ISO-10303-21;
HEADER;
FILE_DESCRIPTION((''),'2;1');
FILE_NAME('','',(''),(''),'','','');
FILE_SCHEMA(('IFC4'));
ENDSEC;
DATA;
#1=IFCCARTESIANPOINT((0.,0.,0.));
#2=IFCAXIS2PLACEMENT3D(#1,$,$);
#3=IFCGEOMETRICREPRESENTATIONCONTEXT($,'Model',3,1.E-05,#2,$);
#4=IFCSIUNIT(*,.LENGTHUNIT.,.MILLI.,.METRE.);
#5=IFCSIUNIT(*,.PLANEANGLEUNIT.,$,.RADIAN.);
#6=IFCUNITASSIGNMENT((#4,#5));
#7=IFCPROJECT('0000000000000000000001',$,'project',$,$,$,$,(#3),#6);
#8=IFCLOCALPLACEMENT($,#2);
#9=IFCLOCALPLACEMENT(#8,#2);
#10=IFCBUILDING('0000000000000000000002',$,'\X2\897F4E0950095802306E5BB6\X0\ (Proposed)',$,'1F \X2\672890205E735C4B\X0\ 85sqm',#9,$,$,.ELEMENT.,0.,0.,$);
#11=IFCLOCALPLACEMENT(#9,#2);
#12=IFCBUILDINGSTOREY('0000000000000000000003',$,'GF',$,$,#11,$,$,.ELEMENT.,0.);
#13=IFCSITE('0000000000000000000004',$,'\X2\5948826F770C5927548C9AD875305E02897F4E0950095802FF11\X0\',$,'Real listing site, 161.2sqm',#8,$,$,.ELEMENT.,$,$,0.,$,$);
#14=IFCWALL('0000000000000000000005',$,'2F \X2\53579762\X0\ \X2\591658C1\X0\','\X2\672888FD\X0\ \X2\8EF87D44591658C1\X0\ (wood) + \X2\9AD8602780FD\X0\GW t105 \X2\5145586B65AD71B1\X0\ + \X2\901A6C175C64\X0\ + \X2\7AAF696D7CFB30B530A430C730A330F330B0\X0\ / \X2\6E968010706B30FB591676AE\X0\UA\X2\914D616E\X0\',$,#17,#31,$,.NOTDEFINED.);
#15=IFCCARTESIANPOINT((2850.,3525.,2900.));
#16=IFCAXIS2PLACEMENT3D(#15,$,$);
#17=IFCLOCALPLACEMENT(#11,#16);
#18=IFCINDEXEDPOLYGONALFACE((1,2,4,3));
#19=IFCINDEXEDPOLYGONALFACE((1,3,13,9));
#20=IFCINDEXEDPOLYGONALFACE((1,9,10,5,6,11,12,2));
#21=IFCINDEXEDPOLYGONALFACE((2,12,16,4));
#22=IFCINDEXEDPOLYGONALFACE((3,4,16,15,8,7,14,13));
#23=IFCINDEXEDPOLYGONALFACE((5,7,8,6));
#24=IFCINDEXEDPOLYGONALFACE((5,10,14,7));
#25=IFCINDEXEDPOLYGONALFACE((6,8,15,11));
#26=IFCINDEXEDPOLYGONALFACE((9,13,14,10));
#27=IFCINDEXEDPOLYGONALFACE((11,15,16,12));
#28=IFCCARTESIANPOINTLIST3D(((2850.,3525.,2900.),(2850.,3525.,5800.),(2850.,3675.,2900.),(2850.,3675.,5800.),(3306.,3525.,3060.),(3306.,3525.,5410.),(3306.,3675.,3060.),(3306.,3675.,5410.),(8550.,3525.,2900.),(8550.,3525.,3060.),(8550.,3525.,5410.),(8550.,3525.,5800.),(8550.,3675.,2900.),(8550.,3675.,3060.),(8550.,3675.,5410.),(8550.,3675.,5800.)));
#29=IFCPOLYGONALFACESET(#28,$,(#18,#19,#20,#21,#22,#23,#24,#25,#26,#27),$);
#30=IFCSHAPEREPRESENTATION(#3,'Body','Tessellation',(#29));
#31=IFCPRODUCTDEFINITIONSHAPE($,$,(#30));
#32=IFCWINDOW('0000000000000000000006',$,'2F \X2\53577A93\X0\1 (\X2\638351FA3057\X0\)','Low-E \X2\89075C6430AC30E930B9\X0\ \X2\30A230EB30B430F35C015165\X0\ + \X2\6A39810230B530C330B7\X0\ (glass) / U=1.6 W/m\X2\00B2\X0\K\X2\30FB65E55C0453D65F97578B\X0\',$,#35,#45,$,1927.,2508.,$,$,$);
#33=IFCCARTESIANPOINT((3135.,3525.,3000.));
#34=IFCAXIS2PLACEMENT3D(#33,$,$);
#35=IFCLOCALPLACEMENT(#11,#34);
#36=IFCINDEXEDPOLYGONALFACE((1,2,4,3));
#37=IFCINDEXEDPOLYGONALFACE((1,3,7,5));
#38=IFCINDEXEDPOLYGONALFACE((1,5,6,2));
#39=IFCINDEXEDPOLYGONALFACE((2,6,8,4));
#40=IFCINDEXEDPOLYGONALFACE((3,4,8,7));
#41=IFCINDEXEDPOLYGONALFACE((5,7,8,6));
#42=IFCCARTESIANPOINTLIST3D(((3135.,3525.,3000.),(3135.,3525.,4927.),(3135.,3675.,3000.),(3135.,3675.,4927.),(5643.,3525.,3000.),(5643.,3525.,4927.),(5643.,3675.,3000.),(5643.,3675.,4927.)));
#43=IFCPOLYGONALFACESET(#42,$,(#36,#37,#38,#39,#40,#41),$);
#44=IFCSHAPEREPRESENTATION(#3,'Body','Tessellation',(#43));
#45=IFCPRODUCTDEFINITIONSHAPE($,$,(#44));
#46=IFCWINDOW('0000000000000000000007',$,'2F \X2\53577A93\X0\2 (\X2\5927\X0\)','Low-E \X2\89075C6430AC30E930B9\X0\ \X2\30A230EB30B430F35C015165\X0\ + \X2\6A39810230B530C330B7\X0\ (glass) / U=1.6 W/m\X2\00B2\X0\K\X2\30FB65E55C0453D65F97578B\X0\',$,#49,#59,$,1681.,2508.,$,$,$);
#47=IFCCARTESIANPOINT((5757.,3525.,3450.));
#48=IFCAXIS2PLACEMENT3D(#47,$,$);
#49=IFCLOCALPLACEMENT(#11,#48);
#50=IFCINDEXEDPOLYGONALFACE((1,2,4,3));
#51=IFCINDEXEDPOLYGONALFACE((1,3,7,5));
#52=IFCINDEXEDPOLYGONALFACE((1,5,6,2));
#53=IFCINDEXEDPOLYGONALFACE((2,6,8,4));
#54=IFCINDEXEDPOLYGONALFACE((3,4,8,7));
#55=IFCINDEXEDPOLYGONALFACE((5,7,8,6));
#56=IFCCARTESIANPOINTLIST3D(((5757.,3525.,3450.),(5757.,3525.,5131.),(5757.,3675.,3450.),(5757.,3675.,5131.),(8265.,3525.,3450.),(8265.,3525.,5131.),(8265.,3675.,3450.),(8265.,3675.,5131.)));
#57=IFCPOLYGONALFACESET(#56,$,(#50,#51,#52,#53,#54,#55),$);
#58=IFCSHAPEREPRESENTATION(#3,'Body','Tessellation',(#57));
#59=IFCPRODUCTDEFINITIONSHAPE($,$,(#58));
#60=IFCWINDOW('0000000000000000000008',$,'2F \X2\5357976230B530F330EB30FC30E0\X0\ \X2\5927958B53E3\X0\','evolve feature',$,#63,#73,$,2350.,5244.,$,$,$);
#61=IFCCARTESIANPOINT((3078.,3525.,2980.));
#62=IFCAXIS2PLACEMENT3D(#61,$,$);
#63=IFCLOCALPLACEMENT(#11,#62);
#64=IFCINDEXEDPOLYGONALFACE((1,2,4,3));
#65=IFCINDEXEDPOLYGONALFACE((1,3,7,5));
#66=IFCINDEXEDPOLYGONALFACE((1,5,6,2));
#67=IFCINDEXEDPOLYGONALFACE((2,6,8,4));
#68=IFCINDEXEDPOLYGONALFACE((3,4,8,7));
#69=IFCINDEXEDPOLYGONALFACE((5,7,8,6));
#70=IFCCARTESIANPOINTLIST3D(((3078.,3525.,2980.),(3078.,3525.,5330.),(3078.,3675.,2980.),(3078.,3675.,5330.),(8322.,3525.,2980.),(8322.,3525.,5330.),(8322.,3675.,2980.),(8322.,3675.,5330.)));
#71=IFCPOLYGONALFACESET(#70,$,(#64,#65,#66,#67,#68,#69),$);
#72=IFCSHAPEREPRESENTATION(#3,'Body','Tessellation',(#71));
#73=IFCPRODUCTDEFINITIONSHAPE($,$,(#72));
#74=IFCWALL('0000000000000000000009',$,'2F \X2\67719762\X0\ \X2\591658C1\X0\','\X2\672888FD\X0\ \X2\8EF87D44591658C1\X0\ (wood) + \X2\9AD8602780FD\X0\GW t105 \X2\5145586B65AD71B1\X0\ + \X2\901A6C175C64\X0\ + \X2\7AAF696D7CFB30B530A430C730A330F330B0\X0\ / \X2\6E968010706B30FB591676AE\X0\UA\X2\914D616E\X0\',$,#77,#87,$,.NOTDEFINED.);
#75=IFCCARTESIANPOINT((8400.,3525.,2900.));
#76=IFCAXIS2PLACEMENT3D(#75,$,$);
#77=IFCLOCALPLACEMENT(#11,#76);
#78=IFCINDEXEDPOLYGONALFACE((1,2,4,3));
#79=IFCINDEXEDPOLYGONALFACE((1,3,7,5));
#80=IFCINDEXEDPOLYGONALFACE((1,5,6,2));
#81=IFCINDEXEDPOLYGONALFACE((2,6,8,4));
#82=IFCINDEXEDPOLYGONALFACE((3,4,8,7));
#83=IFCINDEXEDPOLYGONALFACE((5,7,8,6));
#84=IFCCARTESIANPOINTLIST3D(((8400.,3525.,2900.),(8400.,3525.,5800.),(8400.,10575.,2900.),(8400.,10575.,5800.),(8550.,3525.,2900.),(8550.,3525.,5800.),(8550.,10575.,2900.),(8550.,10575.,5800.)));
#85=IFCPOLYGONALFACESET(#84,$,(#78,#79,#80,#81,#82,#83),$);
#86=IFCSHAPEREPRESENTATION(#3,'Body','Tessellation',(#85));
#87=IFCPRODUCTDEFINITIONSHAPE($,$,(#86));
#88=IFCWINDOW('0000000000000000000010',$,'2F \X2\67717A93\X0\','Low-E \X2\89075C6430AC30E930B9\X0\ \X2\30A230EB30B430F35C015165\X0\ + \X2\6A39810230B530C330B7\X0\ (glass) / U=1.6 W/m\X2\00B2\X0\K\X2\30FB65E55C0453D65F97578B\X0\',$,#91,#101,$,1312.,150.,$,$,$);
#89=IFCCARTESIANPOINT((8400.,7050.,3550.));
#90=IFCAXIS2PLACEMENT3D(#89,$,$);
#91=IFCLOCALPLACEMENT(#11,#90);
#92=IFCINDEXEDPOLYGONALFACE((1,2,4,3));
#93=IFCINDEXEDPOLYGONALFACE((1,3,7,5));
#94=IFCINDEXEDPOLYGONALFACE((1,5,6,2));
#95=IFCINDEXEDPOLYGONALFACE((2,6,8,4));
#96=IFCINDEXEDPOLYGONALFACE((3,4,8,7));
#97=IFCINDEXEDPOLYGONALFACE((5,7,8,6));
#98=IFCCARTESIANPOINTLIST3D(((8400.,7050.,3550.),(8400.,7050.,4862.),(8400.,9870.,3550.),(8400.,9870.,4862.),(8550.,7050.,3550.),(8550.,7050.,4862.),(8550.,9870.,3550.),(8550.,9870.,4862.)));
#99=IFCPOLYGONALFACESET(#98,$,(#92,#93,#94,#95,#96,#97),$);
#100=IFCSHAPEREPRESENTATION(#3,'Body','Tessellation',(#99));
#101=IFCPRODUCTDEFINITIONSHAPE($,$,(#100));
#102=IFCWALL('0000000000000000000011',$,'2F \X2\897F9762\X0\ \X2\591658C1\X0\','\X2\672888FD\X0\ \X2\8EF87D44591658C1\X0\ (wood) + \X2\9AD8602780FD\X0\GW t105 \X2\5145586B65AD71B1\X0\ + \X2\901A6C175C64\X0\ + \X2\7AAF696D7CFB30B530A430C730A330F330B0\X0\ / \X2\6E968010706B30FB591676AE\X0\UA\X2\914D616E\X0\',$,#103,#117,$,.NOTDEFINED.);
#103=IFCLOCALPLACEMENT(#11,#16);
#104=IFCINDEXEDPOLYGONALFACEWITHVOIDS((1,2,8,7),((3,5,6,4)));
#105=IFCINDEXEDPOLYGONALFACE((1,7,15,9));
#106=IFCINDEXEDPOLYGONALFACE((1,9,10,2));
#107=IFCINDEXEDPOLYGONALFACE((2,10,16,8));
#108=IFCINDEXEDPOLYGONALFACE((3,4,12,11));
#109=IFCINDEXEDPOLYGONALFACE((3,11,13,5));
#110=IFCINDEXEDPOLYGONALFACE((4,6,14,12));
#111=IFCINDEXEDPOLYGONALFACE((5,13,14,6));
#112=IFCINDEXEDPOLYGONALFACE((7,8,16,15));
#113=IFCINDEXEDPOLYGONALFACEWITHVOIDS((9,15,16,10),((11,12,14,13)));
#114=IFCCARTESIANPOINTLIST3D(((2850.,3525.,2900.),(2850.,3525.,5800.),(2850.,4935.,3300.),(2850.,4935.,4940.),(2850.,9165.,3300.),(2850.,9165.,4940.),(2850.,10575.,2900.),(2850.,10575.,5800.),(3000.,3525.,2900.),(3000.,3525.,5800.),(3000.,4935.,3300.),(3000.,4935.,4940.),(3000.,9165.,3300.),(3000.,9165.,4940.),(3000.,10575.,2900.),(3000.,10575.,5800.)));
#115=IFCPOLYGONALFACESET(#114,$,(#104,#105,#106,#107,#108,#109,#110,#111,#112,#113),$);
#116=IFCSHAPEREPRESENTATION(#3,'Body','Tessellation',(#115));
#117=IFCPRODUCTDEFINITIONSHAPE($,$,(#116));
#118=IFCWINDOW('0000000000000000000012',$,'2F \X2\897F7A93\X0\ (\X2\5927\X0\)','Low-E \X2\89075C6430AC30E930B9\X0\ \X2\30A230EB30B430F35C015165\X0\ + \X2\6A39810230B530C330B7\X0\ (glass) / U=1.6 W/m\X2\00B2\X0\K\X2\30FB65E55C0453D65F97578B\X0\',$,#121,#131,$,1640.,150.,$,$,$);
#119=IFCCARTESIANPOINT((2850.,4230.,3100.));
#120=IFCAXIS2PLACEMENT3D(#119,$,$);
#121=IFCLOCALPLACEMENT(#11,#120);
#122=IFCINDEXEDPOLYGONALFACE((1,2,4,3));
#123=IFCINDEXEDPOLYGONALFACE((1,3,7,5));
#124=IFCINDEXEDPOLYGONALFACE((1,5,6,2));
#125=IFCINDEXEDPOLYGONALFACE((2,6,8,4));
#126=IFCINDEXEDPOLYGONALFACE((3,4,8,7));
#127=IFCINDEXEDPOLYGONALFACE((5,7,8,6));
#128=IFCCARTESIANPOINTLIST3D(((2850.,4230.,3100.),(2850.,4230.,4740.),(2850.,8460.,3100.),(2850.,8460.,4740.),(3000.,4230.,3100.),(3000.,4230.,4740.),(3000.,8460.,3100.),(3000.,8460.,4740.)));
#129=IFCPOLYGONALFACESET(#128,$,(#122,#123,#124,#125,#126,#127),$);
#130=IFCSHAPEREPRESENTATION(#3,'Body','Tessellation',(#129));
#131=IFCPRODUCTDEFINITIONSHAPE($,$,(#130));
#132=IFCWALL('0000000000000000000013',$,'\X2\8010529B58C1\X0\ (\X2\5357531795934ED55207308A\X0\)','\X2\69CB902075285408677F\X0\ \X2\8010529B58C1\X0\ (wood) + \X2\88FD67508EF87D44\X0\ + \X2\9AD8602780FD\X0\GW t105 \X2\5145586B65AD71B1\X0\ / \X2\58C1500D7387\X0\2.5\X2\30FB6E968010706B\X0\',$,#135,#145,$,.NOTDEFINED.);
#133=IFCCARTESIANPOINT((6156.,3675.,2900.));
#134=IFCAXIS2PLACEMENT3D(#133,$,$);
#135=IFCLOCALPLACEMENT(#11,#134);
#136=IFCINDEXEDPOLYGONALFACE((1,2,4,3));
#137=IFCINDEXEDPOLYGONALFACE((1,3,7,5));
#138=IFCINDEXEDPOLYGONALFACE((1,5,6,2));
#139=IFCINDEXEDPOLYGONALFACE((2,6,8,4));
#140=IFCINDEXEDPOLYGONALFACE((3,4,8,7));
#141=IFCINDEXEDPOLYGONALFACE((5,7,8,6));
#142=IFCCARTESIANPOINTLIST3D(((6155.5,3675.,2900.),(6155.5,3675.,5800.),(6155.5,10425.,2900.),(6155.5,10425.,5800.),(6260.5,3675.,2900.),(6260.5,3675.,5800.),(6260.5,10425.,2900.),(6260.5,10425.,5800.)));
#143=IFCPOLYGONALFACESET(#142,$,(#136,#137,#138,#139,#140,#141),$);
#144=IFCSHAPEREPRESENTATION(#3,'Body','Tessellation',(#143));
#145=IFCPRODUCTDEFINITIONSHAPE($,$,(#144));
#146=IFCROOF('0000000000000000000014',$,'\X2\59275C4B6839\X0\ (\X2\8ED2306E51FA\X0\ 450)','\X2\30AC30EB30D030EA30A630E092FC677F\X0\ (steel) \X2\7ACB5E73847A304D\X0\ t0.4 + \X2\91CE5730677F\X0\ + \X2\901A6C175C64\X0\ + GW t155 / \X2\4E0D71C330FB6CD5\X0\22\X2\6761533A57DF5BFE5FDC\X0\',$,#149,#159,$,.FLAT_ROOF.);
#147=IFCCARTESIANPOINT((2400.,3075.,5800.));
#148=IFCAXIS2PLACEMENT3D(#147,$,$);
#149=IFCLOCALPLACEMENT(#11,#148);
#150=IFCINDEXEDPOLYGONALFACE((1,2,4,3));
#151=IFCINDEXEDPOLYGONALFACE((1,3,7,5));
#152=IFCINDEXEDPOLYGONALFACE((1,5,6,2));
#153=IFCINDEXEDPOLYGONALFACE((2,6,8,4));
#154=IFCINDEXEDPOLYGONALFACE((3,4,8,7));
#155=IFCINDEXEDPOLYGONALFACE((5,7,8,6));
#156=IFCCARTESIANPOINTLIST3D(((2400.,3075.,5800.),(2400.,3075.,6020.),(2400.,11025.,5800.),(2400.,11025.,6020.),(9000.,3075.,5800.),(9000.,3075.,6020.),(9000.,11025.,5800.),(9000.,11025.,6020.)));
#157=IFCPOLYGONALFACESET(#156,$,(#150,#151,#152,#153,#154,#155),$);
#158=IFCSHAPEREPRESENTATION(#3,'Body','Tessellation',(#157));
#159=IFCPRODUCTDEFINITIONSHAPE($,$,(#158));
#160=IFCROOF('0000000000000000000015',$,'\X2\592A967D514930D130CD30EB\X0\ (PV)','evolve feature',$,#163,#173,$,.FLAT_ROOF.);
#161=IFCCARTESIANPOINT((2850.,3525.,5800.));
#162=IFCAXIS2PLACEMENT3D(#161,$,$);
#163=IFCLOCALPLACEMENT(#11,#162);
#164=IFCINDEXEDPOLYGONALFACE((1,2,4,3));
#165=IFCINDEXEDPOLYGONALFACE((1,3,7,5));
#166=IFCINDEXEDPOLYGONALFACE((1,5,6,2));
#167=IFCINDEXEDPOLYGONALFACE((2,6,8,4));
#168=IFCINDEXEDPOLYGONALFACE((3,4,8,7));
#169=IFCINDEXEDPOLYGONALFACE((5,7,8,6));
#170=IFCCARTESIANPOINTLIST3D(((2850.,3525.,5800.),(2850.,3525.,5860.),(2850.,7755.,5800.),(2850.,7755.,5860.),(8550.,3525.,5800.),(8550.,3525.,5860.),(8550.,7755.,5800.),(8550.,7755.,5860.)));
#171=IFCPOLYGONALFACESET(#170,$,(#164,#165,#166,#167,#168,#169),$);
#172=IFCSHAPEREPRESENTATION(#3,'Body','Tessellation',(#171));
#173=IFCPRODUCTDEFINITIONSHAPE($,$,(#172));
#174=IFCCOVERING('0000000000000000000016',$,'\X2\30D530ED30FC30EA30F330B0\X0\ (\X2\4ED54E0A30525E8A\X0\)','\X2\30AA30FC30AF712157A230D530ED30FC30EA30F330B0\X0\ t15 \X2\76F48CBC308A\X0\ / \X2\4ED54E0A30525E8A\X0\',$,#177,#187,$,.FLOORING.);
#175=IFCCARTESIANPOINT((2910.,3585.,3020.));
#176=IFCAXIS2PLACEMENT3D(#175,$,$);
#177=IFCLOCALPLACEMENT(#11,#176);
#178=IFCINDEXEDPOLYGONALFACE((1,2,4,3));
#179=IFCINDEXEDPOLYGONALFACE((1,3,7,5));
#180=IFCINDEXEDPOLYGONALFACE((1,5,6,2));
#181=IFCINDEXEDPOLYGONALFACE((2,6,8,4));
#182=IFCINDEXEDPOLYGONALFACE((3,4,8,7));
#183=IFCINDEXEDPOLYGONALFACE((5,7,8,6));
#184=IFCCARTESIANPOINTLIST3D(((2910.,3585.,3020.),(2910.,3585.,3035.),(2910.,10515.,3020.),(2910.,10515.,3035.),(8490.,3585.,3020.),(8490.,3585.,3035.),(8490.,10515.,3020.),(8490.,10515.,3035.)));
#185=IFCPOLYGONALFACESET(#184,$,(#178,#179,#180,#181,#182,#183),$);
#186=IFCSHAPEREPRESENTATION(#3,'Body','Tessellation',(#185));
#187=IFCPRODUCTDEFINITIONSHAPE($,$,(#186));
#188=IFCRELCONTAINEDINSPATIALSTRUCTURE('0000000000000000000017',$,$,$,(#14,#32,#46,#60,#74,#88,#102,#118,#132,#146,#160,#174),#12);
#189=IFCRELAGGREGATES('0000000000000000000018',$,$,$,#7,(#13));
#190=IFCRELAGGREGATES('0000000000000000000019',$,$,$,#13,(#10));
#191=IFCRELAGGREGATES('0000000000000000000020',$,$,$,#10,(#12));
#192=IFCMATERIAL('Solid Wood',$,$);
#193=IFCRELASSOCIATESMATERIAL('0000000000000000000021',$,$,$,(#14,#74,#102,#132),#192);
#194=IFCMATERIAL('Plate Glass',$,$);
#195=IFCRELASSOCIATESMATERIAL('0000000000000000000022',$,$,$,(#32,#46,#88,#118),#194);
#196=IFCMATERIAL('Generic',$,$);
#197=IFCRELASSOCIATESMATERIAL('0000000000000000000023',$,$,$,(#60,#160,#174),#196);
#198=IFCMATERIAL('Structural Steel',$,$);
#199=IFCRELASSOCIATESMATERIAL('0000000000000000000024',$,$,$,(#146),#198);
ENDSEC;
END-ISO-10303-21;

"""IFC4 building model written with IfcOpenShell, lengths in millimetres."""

from ifc_helpers import new_model, si_unit, frame, frame_2d, origin, place, context, project, spatial, rectangle, extrude, material, element, fill, save


model = new_model("IFC4")

# Units and contexts
model_context = context("Model", 3, precision=1e-05, world=origin())
ifc_project = project(units=[si_unit("LENGTHUNIT", "METRE", prefix="MILLI"), si_unit("PLANEANGLEUNIT", "RADIAN")], contexts=[model_context])

# Site, building, storey
site_placement = place(None, origin())
site = spatial("IfcSite", under=ifc_project, at=site_placement, Name="奈良県大和高田市西三倉堂１", ObjectType="Real listing site, 161.2sqm", CompositionType="ELEMENT", RefElevation=0.0)
building_placement = place(site_placement, origin())
building = spatial("IfcBuilding", under=site, at=building_placement, Name="西三倉堂の家 (Proposed)", ObjectType="1F 木造平屋 85sqm", CompositionType="ELEMENT", ElevationOfRefHeight=0.0, ElevationOfTerrain=0.0)
storey_placement = place(building_placement, origin())
storey = spatial("IfcBuildingStorey", under=building, at=storey_placement, Name="GF", CompositionType="ELEMENT", Elevation=0.0)

# Shared definitions
ifc_material_1 = material(Name="Solid Wood")

# Wall, openings, windows
wall_1_placement = place(storey_placement, frame((2850.0, 3525.0, 2900.0)))
wall_1 = element("IfcWall", 1, at=wall_1_placement, inside=storey, material=ifc_material_1, Name="2F 南面 外壁", Description="木製 軸組外壁 (wood) + 高性能GW t105 充填断熱 + 通気層 + 窯業系サイディング / 準耐火・外皮UA配慮", PredefinedType="NOTDEFINED", context=model_context, shape_type="SweptSolid", body=[
    extrude(rectangle(XDim=5700.0, YDim=150.0, at=frame_2d((2850.0, 75.0))), frame((2850.0, 3525.0, 2900.0)), (0.0, 0.0, 1.0), 2900.0),
])
opening_1_placement = place(storey_placement, frame((3135.0, 3525.0, 3000.0)))
opening_1 = element("IfcOpeningElement", 2, at=opening_1_placement, cuts=wall_1, PredefinedType="NOTDEFINED", context=model_context, shape_type="SweptSolid", body=[
    extrude(rectangle(XDim=2508.0, YDim=150.0, at=frame_2d((1254.0, 75.0))), frame((3135.0, 3525.0, 3000.0)), (0.0, 0.0, 1.0), 1927.0),
])
opening_2_placement = place(storey_placement, frame((5757.0, 3525.0, 3450.0)))
opening_2 = element("IfcOpeningElement", 3, at=opening_2_placement, cuts=wall_1, PredefinedType="NOTDEFINED", context=model_context, shape_type="SweptSolid", body=[
    extrude(rectangle(XDim=2508.0, YDim=150.0, at=frame_2d((1254.0, 75.0))), frame((5757.0, 3525.0, 3450.0)), (0.0, 0.0, 1.0), 1681.0),
])
opening_3_placement = place(storey_placement, frame((3078.0, 3525.0, 2980.0)))
opening_3 = element("IfcOpeningElement", 4, at=opening_3_placement, cuts=wall_1, PredefinedType="NOTDEFINED", context=model_context, shape_type="SweptSolid", body=[
    extrude(rectangle(XDim=5244.0, YDim=150.0, at=frame_2d((2622.0, 75.0))), frame((3078.0, 3525.0, 2980.0)), (0.0, 0.0, 1.0), 2350.0),
])
ifc_material_2 = material(Name="Plate Glass")
window_1_placement = place(storey_placement, frame((3135.0, 3525.0, 3000.0)))
window_1 = element("IfcWindow", 5, at=window_1_placement, inside=storey, material=ifc_material_2, Name="2F 南窓1 (掃出し)", Description="Low-E 複層ガラス アルゴン封入 + 樹脂サッシ (glass) / U=1.6 W/m²K・日射取得型", OverallHeight=1927.0, OverallWidth=2508.0, context=model_context, shape_type="SweptSolid", body=[
    extrude(rectangle(XDim=2508.0, YDim=150.0, at=frame_2d((1254.0, 75.0))), frame((3135.0, 3525.0, 3000.0)), (0.0, 0.0, 1.0), 1927.0),
])
fill(opening_1, window_1)
window_2_placement = place(storey_placement, frame((5757.0, 3525.0, 3450.0)))
window_2 = element("IfcWindow", 6, at=window_2_placement, inside=storey, material=ifc_material_2, Name="2F 南窓2 (大)", Description="Low-E 複層ガラス アルゴン封入 + 樹脂サッシ (glass) / U=1.6 W/m²K・日射取得型", OverallHeight=1681.0, OverallWidth=2508.0, context=model_context, shape_type="SweptSolid", body=[
    extrude(rectangle(XDim=2508.0, YDim=150.0, at=frame_2d((1254.0, 75.0))), frame((5757.0, 3525.0, 3450.0)), (0.0, 0.0, 1.0), 1681.0),
])
fill(opening_2, window_2)
ifc_material_3 = material(Name="Generic")
window_3_placement = place(storey_placement, frame((3078.0, 3525.0, 2980.0)))
window_3 = element("IfcWindow", 7, at=window_3_placement, inside=storey, material=ifc_material_3, Name="2F 南面サンルーム 大開口", Description="evolve feature", OverallHeight=2350.0, OverallWidth=5244.0, context=model_context, shape_type="SweptSolid", body=[
    extrude(rectangle(XDim=5244.0, YDim=150.0, at=frame_2d((2622.0, 75.0))), frame((3078.0, 3525.0, 2980.0)), (0.0, 0.0, 1.0), 2350.0),
])
fill(opening_3, window_3)

# Walls, openings, windows
wall_2_placement = place(storey_placement, frame((8400.0, 3525.0, 2900.0)))
wall_2 = element("IfcWall", 8, at=wall_2_placement, inside=storey, material=ifc_material_1, Name="2F 東面 外壁", Description="木製 軸組外壁 (wood) + 高性能GW t105 充填断熱 + 通気層 + 窯業系サイディング / 準耐火・外皮UA配慮", PredefinedType="NOTDEFINED", context=model_context, shape_type="SweptSolid", body=[
    extrude(rectangle(XDim=150.0, YDim=7050.0, at=frame_2d((75.0, 3525.0))), frame((8400.0, 3525.0, 2900.0)), (0.0, 0.0, 1.0), 2900.0),
])
opening_4_placement = place(storey_placement, frame((8400.0, 7050.0, 3550.0)))
opening_4 = element("IfcOpeningElement", 9, at=opening_4_placement, cuts=wall_2, PredefinedType="NOTDEFINED", context=model_context, shape_type="SweptSolid", body=[
    extrude(rectangle(XDim=150.0, YDim=2820.0, at=frame_2d((75.0, 1410.0))), frame((8400.0, 7050.0, 3550.0)), (0.0, 0.0, 1.0), 1312.0),
])
window_4_placement = place(storey_placement, frame((8400.0, 7050.0, 3550.0)))
window_4 = element("IfcWindow", 10, at=window_4_placement, inside=storey, material=ifc_material_2, Name="2F 東窓", Description="Low-E 複層ガラス アルゴン封入 + 樹脂サッシ (glass) / U=1.6 W/m²K・日射取得型", OverallHeight=1312.0, OverallWidth=150.0, context=model_context, shape_type="SweptSolid", body=[
    extrude(rectangle(XDim=150.0, YDim=2820.0, at=frame_2d((75.0, 1410.0))), frame((8400.0, 7050.0, 3550.0)), (0.0, 0.0, 1.0), 1312.0),
])
fill(opening_4, window_4)
wall_3_placement = place(storey_placement, frame((2850.0, 3525.0, 2900.0)))
wall_3 = element("IfcWall", 11, at=wall_3_placement, inside=storey, material=ifc_material_1, Name="2F 西面 外壁", Description="木製 軸組外壁 (wood) + 高性能GW t105 充填断熱 + 通気層 + 窯業系サイディング / 準耐火・外皮UA配慮", PredefinedType="NOTDEFINED", context=model_context, shape_type="SweptSolid", body=[
    extrude(rectangle(XDim=150.0, YDim=7050.0, at=frame_2d((75.0, 3525.0))), frame((2850.0, 3525.0, 2900.0)), (0.0, 0.0, 1.0), 2900.0),
])
opening_5_placement = place(storey_placement, frame((2850.0, 4230.0, 3100.0)))
opening_5 = element("IfcOpeningElement", 12, at=opening_5_placement, cuts=wall_3, PredefinedType="NOTDEFINED", context=model_context, shape_type="SweptSolid", body=[
    extrude(rectangle(XDim=150.0, YDim=4230.0, at=frame_2d((75.0, 2115.0))), frame((2850.0, 4230.0, 3100.0)), (0.0, 0.0, 1.0), 1640.0),
])
window_5_placement = place(storey_placement, frame((2850.0, 4230.0, 3100.0)))
window_5 = element("IfcWindow", 13, at=window_5_placement, inside=storey, material=ifc_material_2, Name="2F 西窓 (大)", Description="Low-E 複層ガラス アルゴン封入 + 樹脂サッシ (glass) / U=1.6 W/m²K・日射取得型", OverallHeight=1640.0, OverallWidth=150.0, context=model_context, shape_type="SweptSolid", body=[
    extrude(rectangle(XDim=150.0, YDim=4230.0, at=frame_2d((75.0, 2115.0))), frame((2850.0, 4230.0, 3100.0)), (0.0, 0.0, 1.0), 1640.0),
])
fill(opening_5, window_5)

# Wall
wall_4_placement = place(storey_placement, frame((6156.0, 3675.0, 2900.0)))
element("IfcWall", 14, at=wall_4_placement, inside=storey, material=ifc_material_1, Name="耐力壁 (南北間仕切り)", Description="構造用合板 耐力壁 (wood) + 製材軸組 + 高性能GW t105 充填断熱 / 壁倍率2.5・準耐火", PredefinedType="NOTDEFINED", context=model_context, shape_type="SweptSolid", body=[
    extrude(rectangle(XDim=105.0, YDim=6750.0, at=frame_2d((52.0, 3375.0))), frame((6156.0, 3675.0, 2900.0)), (0.0, 0.0, 1.0), 2900.0),
])

# Roofs
ifc_material_4 = material(Name="Structural Steel")
roof_1_placement = place(storey_placement, frame((2400.0, 3075.0, 5800.0)))
element("IfcRoof", 15, at=roof_1_placement, inside=storey, material=ifc_material_4, Name="大屋根 (軒の出 450)", Description="ガルバリウム鋼板 (steel) 立平葺き t0.4 + 野地板 + 通気層 + GW t155 / 不燃・法22条区域対応", PredefinedType="FLAT_ROOF", context=model_context, shape_type="SweptSolid", body=[
    extrude(rectangle(XDim=6600.0, YDim=7950.0, at=frame_2d((3300.0, 3975.0))), frame((2400.0, 3075.0, 5800.0)), (0.0, 0.0, 1.0), 220.0),
])
roof_2_placement = place(storey_placement, frame((2850.0, 3525.0, 5800.0)))
element("IfcRoof", 16, at=roof_2_placement, inside=storey, material=ifc_material_3, Name="太陽光パネル (PV)", Description="evolve feature", PredefinedType="FLAT_ROOF", context=model_context, shape_type="SweptSolid", body=[
    extrude(rectangle(XDim=5700.0, YDim=4230.0, at=frame_2d((2850.0, 2115.0))), frame((2850.0, 3525.0, 5800.0)), (0.0, 0.0, 1.0), 60.0),
])

# Covering
covering_placement = place(storey_placement, frame((2910.0, 3585.0, 3020.0)))
element("IfcCovering", 17, at=covering_placement, inside=storey, material=ifc_material_3, Name="フローリング (仕上げ床)", Description="オーク無垢フローリング t15 直貼り / 仕上げ床", PredefinedType="FLOORING", context=model_context, shape_type="SweptSolid", body=[
    extrude(rectangle(XDim=5580.0, YDim=6930.0, at=frame_2d((2790.0, 3465.0))), frame((2910.0, 3585.0, 3020.0)), (0.0, 0.0, 1.0), 15.0),
])

save(model, "model.ifc")
